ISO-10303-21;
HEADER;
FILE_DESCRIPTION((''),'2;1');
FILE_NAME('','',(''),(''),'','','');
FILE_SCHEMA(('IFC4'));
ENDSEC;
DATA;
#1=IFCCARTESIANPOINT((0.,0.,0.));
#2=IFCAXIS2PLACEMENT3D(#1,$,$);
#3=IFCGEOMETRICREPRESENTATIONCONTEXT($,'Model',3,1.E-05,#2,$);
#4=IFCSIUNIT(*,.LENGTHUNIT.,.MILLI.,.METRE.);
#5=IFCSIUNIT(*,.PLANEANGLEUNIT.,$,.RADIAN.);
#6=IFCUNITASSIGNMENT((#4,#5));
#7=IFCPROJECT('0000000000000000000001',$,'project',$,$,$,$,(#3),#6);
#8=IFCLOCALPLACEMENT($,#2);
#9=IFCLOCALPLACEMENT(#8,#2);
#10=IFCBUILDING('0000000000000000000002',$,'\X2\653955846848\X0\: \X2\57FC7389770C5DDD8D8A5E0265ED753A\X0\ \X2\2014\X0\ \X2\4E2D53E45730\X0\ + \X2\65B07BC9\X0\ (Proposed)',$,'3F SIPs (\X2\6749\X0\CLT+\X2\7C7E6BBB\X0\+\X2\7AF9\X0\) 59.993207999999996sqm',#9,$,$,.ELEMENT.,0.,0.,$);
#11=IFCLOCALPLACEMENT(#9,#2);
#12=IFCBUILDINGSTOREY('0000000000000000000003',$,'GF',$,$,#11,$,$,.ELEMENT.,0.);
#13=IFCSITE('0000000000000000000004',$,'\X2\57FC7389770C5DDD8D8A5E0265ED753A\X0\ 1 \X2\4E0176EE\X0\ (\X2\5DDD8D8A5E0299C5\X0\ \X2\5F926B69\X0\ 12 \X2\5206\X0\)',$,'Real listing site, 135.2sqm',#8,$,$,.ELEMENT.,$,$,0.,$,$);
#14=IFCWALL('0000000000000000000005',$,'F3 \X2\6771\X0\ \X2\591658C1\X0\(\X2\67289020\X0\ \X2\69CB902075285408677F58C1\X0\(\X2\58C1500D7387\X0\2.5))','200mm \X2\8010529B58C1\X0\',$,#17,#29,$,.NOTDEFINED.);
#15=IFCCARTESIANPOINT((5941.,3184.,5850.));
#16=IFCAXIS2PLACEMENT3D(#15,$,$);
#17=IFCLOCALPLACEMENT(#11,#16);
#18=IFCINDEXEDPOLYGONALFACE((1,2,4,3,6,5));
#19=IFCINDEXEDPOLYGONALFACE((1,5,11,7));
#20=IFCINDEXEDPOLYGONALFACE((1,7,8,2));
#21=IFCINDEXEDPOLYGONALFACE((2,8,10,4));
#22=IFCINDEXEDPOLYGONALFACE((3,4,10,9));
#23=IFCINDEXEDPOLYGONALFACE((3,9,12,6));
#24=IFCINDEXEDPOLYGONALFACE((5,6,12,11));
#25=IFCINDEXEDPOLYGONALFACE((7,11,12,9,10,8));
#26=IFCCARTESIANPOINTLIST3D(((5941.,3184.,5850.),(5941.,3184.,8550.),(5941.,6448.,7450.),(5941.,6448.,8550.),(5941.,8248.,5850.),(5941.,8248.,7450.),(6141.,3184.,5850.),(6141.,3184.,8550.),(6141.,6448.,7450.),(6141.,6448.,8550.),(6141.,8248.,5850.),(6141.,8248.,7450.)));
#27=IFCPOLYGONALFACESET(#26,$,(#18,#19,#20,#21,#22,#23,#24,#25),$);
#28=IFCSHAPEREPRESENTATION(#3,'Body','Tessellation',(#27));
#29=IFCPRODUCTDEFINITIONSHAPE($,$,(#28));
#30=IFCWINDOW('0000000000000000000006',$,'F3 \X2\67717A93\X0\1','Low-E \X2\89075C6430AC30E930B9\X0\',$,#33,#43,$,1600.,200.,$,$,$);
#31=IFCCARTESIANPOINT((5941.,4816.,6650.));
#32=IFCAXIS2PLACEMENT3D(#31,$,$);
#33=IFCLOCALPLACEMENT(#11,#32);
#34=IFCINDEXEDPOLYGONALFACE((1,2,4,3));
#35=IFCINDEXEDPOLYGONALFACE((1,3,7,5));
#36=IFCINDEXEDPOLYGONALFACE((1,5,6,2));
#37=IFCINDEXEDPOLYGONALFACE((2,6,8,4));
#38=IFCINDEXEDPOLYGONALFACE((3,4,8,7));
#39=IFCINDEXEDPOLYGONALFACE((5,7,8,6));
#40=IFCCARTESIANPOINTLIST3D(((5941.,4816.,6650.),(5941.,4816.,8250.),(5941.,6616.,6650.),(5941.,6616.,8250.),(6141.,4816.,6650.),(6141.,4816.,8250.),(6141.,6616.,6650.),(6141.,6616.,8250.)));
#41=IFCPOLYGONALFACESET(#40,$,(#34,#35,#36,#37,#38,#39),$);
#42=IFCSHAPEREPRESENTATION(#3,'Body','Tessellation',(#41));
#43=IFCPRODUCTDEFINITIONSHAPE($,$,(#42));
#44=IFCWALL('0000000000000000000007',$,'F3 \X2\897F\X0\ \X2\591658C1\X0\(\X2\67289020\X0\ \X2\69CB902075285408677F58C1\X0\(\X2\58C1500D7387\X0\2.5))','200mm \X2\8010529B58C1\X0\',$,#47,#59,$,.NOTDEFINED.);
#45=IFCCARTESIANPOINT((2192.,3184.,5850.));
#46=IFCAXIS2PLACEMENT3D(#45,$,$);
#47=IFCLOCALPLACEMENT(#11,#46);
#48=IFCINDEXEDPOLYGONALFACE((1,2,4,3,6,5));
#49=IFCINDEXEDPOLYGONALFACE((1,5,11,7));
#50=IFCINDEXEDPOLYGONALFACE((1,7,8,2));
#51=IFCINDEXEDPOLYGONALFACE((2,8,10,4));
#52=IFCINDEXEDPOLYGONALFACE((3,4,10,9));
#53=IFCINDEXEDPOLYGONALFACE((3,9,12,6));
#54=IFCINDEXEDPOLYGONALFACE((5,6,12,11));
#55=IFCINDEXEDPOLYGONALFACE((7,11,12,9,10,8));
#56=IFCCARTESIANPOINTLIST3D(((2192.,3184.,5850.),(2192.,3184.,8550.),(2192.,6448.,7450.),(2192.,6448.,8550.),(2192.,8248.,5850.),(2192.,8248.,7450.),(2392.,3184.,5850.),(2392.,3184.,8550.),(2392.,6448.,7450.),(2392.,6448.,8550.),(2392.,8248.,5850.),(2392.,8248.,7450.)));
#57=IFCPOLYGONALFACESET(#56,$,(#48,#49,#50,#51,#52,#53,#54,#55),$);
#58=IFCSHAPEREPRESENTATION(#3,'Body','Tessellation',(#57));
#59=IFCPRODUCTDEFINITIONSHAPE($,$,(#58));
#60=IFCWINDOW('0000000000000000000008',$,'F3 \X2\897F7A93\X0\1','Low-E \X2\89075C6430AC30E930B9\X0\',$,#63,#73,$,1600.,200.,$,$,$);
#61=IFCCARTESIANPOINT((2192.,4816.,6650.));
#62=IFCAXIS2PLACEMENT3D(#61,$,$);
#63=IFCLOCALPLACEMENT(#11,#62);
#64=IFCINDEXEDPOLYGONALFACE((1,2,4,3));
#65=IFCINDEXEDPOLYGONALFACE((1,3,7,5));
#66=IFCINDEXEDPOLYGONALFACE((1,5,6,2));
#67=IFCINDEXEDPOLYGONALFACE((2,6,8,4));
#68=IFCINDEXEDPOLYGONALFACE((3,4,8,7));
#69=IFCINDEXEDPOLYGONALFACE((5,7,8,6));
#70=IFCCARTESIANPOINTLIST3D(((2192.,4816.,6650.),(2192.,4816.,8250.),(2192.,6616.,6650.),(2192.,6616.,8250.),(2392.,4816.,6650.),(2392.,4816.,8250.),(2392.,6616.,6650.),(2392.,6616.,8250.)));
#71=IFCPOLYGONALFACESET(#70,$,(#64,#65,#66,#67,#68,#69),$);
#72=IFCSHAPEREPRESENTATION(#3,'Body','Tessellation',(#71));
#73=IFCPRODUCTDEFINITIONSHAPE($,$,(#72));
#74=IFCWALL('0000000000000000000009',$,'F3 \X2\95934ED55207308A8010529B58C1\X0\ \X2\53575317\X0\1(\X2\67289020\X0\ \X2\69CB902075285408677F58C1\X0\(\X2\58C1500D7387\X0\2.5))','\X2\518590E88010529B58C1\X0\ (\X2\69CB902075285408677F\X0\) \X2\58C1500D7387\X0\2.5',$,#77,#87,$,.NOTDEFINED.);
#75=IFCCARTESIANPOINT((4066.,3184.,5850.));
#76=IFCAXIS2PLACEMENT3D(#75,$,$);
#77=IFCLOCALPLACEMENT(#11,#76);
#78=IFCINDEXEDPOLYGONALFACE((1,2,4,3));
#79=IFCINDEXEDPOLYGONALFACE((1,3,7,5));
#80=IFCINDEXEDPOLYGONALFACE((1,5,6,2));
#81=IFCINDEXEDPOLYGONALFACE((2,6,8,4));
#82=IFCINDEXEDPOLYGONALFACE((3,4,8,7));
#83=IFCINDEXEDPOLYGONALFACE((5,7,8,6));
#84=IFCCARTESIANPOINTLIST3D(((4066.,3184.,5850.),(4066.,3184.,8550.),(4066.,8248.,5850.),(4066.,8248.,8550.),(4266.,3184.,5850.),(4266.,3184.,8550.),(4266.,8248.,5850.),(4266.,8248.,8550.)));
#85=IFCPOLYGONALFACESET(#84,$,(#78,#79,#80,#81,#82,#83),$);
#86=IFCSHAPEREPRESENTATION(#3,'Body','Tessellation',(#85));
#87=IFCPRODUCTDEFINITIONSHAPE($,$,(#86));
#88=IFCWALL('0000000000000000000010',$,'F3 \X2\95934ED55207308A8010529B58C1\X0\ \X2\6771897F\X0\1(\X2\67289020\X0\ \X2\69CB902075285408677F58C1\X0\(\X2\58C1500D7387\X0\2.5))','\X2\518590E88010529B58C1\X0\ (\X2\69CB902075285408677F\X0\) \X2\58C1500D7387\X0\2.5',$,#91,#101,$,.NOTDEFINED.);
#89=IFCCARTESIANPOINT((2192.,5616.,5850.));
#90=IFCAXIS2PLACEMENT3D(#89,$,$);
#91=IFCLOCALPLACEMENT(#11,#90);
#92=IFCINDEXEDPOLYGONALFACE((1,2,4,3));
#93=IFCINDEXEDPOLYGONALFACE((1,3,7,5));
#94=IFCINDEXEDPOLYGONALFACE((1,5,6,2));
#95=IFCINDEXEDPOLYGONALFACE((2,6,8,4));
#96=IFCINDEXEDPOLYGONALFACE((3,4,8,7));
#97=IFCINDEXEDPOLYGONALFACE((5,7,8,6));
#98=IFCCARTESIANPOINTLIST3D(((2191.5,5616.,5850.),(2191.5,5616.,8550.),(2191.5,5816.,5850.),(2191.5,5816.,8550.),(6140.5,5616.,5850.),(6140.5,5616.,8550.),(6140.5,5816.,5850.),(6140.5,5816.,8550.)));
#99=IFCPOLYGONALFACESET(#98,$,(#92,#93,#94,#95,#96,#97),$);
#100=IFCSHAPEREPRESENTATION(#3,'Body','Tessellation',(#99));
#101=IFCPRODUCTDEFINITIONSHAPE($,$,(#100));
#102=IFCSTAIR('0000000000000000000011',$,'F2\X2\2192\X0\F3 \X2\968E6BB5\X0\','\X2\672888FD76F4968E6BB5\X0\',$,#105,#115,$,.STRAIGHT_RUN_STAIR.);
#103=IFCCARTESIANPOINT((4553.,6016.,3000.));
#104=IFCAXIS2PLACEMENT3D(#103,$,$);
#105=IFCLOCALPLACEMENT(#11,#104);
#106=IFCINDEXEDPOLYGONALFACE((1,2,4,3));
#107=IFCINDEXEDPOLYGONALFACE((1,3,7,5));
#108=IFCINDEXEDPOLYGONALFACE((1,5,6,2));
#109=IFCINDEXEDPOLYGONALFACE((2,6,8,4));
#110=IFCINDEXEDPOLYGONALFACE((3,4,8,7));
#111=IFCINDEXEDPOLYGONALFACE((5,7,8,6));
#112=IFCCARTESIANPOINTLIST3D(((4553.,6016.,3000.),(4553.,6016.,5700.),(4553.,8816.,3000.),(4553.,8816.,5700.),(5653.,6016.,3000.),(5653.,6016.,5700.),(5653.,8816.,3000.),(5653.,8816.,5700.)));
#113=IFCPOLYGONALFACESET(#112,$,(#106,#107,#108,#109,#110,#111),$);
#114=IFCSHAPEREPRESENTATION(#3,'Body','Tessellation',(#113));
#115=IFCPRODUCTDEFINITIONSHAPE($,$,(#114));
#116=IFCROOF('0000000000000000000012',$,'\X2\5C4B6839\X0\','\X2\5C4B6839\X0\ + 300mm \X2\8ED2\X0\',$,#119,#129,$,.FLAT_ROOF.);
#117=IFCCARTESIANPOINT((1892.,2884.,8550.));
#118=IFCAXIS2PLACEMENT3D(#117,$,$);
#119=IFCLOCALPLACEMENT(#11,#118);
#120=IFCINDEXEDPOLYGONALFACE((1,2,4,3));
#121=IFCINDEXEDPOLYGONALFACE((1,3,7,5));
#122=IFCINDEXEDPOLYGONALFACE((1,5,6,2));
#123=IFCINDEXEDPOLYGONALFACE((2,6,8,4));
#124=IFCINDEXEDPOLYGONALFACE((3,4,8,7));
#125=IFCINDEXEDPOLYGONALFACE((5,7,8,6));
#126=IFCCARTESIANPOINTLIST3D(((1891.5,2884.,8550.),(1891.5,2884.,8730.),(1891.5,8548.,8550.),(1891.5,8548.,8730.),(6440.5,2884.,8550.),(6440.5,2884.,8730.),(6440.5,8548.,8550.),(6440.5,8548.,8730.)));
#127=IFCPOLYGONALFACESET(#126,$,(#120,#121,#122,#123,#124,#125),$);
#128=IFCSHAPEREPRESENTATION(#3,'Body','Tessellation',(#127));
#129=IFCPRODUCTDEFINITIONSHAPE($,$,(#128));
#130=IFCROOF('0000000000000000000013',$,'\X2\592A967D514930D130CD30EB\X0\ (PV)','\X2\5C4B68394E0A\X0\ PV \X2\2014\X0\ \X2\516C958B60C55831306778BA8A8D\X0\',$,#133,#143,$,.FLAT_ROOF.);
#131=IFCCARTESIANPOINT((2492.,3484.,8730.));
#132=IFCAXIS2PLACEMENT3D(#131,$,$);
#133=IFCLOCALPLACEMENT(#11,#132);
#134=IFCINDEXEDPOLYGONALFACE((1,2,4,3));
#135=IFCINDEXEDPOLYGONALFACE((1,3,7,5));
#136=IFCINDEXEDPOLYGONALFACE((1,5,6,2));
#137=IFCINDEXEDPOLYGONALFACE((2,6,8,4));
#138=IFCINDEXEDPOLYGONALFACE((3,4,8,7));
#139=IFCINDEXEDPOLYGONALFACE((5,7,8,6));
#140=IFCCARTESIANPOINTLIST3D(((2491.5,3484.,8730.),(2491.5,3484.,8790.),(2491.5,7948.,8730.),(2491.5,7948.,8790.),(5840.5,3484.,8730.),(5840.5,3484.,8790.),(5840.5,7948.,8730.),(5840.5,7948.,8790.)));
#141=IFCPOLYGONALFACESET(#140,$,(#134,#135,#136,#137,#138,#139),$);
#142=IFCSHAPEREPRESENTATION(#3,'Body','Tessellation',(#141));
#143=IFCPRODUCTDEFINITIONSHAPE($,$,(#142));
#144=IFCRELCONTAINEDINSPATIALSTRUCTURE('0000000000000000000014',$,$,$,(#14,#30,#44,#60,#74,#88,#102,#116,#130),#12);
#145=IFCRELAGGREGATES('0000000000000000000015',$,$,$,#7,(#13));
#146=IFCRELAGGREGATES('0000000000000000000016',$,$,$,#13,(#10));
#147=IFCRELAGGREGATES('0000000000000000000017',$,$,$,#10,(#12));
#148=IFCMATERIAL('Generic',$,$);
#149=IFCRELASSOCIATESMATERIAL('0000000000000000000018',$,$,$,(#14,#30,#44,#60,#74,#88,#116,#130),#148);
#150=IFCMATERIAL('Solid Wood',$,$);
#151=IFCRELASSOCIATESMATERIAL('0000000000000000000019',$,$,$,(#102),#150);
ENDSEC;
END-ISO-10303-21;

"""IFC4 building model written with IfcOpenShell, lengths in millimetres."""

from ifc_helpers import new_model, si_unit, frame, frame_2d, origin, place, context, project, spatial, rectangle, extrude, material, element, fill, save


model = new_model("IFC4")

# Units and contexts
model_context = context("Model", 3, precision=1e-05, world=origin())
ifc_project = project(units=[si_unit("LENGTHUNIT", "METRE", prefix="MILLI"), si_unit("PLANEANGLEUNIT", "RADIAN")], contexts=[model_context])

# Site, building, storey
site_placement = place(None, origin())
site = spatial("IfcSite", under=ifc_project, at=site_placement, Name="埼玉県川越市旭町 1 丁目 (川越市駅 徒歩 12 分)", ObjectType="Real listing site, 135.2sqm", CompositionType="ELEMENT", RefElevation=0.0)
building_placement = place(site_placement, origin())
building = spatial("IfcBuilding", under=site, at=building_placement, Name="改善案: 埼玉県川越市旭町 — 中古地 + 新築 (Proposed)", ObjectType="3F SIPs (杉CLT+籾殻+竹) 59.993207999999996sqm", CompositionType="ELEMENT", ElevationOfRefHeight=0.0, ElevationOfTerrain=0.0)
storey_placement = place(building_placement, origin())
storey = spatial("IfcBuildingStorey", under=building, at=storey_placement, Name="GF", CompositionType="ELEMENT", Elevation=0.0)

# Shared definitions
ifc_material_1 = material(Name="Generic")

# Walls, openings, windows
wall_1_placement = place(storey_placement, frame((5941.0, 3184.0, 5850.0)))
wall_1 = element("IfcWall", 1, at=wall_1_placement, inside=storey, material=ifc_material_1, Name="F3 東 外壁(木造 構造用合板壁(壁倍率2.5))", Description="200mm 耐力壁", PredefinedType="NOTDEFINED", context=model_context, shape_type="SweptSolid", body=[
    extrude(rectangle(XDim=200.0, YDim=5064.0, at=frame_2d((100.0, 2532.0))), frame((5941.0, 3184.0, 5850.0)), (0.0, 0.0, 1.0), 2700.0),
])
opening_1_placement = place(storey_placement, frame((5941.0, 4816.0, 6650.0)))
opening_1 = element("IfcOpeningElement", 2, at=opening_1_placement, cuts=wall_1, PredefinedType="NOTDEFINED", context=model_context, shape_type="SweptSolid", body=[
    extrude(rectangle(XDim=200.0, YDim=1800.0, at=frame_2d((100.0, 900.0))), frame((5941.0, 4816.0, 6650.0)), (0.0, 0.0, 1.0), 1600.0),
])
window_1_placement = place(storey_placement, frame((5941.0, 4816.0, 6650.0)))
window_1 = element("IfcWindow", 3, at=window_1_placement, inside=storey, material=ifc_material_1, Name="F3 東窓1", Description="Low-E 複層ガラス", OverallHeight=1600.0, OverallWidth=200.0, context=model_context, shape_type="SweptSolid", body=[
    extrude(rectangle(XDim=200.0, YDim=1800.0, at=frame_2d((100.0, 900.0))), frame((5941.0, 4816.0, 6650.0)), (0.0, 0.0, 1.0), 1600.0),
])
fill(opening_1, window_1)
wall_2_placement = place(storey_placement, frame((2192.0, 3184.0, 5850.0)))
wall_2 = element("IfcWall", 4, at=wall_2_placement, inside=storey, material=ifc_material_1, Name="F3 西 外壁(木造 構造用合板壁(壁倍率2.5))", Description="200mm 耐力壁", PredefinedType="NOTDEFINED", context=model_context, shape_type="SweptSolid", body=[
    extrude(rectangle(XDim=200.0, YDim=5064.0, at=frame_2d((100.0, 2532.0))), frame((2192.0, 3184.0, 5850.0)), (0.0, 0.0, 1.0), 2700.0),
])
opening_2_placement = place(storey_placement, frame((2192.0, 4816.0, 6650.0)))
opening_2 = element("IfcOpeningElement", 5, at=opening_2_placement, cuts=wall_2, PredefinedType="NOTDEFINED", context=model_context, shape_type="SweptSolid", body=[
    extrude(rectangle(XDim=200.0, YDim=1800.0, at=frame_2d((100.0, 900.0))), frame((2192.0, 4816.0, 6650.0)), (0.0, 0.0, 1.0), 1600.0),
])
window_2_placement = place(storey_placement, frame((2192.0, 4816.0, 6650.0)))
window_2 = element("IfcWindow", 6, at=window_2_placement, inside=storey, material=ifc_material_1, Name="F3 西窓1", Description="Low-E 複層ガラス", OverallHeight=1600.0, OverallWidth=200.0, context=model_context, shape_type="SweptSolid", body=[
    extrude(rectangle(XDim=200.0, YDim=1800.0, at=frame_2d((100.0, 900.0))), frame((2192.0, 4816.0, 6650.0)), (0.0, 0.0, 1.0), 1600.0),
])
fill(opening_2, window_2)

# Walls
wall_3_placement = place(storey_placement, frame((4066.0, 3184.0, 5850.0)))
element("IfcWall", 7, at=wall_3_placement, inside=storey, material=ifc_material_1, Name="F3 間仕切り耐力壁 南北1(木造 構造用合板壁(壁倍率2.5))", Description="内部耐力壁 (構造用合板) 壁倍率2.5", PredefinedType="NOTDEFINED", context=model_context, shape_type="SweptSolid", body=[
    extrude(rectangle(XDim=200.0, YDim=5064.0, at=frame_2d((100.0, 2532.0))), frame((4066.0, 3184.0, 5850.0)), (0.0, 0.0, 1.0), 2700.0),
])
wall_4_placement = place(storey_placement, frame((2192.0, 5616.0, 5850.0)))
element("IfcWall", 8, at=wall_4_placement, inside=storey, material=ifc_material_1, Name="F3 間仕切り耐力壁 東西1(木造 構造用合板壁(壁倍率2.5))", Description="内部耐力壁 (構造用合板) 壁倍率2.5", PredefinedType="NOTDEFINED", context=model_context, shape_type="SweptSolid", body=[
    extrude(rectangle(XDim=3949.0, YDim=200.0, at=frame_2d((1974.0, 100.0))), frame((2192.0, 5616.0, 5850.0)), (0.0, 0.0, 1.0), 2700.0),
])

# Stair
ifc_material_2 = material(Name="Solid Wood")
stair_placement = place(storey_placement, frame((4553.0, 6016.0, 3000.0)))
element("IfcStair", 9, at=stair_placement, inside=storey, material=ifc_material_2, Name="F2→F3 階段", Description="木製直階段", PredefinedType="STRAIGHT_RUN_STAIR", context=model_context, shape_type="SweptSolid", body=[
    extrude(rectangle(XDim=1100.0, YDim=2800.0, at=frame_2d((550.0, 1400.0))), frame((4553.0, 6016.0, 3000.0)), (0.0, 0.0, 1.0), 2700.0),
])

# Roofs
roof_1_placement = place(storey_placement, frame((1892.0, 2884.0, 8550.0)))
element("IfcRoof", 10, at=roof_1_placement, inside=storey, material=ifc_material_1, Name="屋根", Description="屋根 + 300mm 軒", PredefinedType="FLAT_ROOF", context=model_context, shape_type="SweptSolid", body=[
    extrude(rectangle(XDim=4549.0, YDim=5664.0, at=frame_2d((2274.0, 2832.0))), frame((1892.0, 2884.0, 8550.0)), (0.0, 0.0, 1.0), 180.0),
])
roof_2_placement = place(storey_placement, frame((2492.0, 3484.0, 8730.0)))
element("IfcRoof", 11, at=roof_2_placement, inside=storey, material=ifc_material_1, Name="太陽光パネル (PV)", Description="屋根上 PV — 公開情報で確認", PredefinedType="FLAT_ROOF", context=model_context, shape_type="SweptSolid", body=[
    extrude(rectangle(XDim=3349.0, YDim=4464.0, at=frame_2d((1674.0, 2232.0))), frame((2492.0, 3484.0, 8730.0)), (0.0, 0.0, 1.0), 60.0),
])

save(model, "model.ifc")
